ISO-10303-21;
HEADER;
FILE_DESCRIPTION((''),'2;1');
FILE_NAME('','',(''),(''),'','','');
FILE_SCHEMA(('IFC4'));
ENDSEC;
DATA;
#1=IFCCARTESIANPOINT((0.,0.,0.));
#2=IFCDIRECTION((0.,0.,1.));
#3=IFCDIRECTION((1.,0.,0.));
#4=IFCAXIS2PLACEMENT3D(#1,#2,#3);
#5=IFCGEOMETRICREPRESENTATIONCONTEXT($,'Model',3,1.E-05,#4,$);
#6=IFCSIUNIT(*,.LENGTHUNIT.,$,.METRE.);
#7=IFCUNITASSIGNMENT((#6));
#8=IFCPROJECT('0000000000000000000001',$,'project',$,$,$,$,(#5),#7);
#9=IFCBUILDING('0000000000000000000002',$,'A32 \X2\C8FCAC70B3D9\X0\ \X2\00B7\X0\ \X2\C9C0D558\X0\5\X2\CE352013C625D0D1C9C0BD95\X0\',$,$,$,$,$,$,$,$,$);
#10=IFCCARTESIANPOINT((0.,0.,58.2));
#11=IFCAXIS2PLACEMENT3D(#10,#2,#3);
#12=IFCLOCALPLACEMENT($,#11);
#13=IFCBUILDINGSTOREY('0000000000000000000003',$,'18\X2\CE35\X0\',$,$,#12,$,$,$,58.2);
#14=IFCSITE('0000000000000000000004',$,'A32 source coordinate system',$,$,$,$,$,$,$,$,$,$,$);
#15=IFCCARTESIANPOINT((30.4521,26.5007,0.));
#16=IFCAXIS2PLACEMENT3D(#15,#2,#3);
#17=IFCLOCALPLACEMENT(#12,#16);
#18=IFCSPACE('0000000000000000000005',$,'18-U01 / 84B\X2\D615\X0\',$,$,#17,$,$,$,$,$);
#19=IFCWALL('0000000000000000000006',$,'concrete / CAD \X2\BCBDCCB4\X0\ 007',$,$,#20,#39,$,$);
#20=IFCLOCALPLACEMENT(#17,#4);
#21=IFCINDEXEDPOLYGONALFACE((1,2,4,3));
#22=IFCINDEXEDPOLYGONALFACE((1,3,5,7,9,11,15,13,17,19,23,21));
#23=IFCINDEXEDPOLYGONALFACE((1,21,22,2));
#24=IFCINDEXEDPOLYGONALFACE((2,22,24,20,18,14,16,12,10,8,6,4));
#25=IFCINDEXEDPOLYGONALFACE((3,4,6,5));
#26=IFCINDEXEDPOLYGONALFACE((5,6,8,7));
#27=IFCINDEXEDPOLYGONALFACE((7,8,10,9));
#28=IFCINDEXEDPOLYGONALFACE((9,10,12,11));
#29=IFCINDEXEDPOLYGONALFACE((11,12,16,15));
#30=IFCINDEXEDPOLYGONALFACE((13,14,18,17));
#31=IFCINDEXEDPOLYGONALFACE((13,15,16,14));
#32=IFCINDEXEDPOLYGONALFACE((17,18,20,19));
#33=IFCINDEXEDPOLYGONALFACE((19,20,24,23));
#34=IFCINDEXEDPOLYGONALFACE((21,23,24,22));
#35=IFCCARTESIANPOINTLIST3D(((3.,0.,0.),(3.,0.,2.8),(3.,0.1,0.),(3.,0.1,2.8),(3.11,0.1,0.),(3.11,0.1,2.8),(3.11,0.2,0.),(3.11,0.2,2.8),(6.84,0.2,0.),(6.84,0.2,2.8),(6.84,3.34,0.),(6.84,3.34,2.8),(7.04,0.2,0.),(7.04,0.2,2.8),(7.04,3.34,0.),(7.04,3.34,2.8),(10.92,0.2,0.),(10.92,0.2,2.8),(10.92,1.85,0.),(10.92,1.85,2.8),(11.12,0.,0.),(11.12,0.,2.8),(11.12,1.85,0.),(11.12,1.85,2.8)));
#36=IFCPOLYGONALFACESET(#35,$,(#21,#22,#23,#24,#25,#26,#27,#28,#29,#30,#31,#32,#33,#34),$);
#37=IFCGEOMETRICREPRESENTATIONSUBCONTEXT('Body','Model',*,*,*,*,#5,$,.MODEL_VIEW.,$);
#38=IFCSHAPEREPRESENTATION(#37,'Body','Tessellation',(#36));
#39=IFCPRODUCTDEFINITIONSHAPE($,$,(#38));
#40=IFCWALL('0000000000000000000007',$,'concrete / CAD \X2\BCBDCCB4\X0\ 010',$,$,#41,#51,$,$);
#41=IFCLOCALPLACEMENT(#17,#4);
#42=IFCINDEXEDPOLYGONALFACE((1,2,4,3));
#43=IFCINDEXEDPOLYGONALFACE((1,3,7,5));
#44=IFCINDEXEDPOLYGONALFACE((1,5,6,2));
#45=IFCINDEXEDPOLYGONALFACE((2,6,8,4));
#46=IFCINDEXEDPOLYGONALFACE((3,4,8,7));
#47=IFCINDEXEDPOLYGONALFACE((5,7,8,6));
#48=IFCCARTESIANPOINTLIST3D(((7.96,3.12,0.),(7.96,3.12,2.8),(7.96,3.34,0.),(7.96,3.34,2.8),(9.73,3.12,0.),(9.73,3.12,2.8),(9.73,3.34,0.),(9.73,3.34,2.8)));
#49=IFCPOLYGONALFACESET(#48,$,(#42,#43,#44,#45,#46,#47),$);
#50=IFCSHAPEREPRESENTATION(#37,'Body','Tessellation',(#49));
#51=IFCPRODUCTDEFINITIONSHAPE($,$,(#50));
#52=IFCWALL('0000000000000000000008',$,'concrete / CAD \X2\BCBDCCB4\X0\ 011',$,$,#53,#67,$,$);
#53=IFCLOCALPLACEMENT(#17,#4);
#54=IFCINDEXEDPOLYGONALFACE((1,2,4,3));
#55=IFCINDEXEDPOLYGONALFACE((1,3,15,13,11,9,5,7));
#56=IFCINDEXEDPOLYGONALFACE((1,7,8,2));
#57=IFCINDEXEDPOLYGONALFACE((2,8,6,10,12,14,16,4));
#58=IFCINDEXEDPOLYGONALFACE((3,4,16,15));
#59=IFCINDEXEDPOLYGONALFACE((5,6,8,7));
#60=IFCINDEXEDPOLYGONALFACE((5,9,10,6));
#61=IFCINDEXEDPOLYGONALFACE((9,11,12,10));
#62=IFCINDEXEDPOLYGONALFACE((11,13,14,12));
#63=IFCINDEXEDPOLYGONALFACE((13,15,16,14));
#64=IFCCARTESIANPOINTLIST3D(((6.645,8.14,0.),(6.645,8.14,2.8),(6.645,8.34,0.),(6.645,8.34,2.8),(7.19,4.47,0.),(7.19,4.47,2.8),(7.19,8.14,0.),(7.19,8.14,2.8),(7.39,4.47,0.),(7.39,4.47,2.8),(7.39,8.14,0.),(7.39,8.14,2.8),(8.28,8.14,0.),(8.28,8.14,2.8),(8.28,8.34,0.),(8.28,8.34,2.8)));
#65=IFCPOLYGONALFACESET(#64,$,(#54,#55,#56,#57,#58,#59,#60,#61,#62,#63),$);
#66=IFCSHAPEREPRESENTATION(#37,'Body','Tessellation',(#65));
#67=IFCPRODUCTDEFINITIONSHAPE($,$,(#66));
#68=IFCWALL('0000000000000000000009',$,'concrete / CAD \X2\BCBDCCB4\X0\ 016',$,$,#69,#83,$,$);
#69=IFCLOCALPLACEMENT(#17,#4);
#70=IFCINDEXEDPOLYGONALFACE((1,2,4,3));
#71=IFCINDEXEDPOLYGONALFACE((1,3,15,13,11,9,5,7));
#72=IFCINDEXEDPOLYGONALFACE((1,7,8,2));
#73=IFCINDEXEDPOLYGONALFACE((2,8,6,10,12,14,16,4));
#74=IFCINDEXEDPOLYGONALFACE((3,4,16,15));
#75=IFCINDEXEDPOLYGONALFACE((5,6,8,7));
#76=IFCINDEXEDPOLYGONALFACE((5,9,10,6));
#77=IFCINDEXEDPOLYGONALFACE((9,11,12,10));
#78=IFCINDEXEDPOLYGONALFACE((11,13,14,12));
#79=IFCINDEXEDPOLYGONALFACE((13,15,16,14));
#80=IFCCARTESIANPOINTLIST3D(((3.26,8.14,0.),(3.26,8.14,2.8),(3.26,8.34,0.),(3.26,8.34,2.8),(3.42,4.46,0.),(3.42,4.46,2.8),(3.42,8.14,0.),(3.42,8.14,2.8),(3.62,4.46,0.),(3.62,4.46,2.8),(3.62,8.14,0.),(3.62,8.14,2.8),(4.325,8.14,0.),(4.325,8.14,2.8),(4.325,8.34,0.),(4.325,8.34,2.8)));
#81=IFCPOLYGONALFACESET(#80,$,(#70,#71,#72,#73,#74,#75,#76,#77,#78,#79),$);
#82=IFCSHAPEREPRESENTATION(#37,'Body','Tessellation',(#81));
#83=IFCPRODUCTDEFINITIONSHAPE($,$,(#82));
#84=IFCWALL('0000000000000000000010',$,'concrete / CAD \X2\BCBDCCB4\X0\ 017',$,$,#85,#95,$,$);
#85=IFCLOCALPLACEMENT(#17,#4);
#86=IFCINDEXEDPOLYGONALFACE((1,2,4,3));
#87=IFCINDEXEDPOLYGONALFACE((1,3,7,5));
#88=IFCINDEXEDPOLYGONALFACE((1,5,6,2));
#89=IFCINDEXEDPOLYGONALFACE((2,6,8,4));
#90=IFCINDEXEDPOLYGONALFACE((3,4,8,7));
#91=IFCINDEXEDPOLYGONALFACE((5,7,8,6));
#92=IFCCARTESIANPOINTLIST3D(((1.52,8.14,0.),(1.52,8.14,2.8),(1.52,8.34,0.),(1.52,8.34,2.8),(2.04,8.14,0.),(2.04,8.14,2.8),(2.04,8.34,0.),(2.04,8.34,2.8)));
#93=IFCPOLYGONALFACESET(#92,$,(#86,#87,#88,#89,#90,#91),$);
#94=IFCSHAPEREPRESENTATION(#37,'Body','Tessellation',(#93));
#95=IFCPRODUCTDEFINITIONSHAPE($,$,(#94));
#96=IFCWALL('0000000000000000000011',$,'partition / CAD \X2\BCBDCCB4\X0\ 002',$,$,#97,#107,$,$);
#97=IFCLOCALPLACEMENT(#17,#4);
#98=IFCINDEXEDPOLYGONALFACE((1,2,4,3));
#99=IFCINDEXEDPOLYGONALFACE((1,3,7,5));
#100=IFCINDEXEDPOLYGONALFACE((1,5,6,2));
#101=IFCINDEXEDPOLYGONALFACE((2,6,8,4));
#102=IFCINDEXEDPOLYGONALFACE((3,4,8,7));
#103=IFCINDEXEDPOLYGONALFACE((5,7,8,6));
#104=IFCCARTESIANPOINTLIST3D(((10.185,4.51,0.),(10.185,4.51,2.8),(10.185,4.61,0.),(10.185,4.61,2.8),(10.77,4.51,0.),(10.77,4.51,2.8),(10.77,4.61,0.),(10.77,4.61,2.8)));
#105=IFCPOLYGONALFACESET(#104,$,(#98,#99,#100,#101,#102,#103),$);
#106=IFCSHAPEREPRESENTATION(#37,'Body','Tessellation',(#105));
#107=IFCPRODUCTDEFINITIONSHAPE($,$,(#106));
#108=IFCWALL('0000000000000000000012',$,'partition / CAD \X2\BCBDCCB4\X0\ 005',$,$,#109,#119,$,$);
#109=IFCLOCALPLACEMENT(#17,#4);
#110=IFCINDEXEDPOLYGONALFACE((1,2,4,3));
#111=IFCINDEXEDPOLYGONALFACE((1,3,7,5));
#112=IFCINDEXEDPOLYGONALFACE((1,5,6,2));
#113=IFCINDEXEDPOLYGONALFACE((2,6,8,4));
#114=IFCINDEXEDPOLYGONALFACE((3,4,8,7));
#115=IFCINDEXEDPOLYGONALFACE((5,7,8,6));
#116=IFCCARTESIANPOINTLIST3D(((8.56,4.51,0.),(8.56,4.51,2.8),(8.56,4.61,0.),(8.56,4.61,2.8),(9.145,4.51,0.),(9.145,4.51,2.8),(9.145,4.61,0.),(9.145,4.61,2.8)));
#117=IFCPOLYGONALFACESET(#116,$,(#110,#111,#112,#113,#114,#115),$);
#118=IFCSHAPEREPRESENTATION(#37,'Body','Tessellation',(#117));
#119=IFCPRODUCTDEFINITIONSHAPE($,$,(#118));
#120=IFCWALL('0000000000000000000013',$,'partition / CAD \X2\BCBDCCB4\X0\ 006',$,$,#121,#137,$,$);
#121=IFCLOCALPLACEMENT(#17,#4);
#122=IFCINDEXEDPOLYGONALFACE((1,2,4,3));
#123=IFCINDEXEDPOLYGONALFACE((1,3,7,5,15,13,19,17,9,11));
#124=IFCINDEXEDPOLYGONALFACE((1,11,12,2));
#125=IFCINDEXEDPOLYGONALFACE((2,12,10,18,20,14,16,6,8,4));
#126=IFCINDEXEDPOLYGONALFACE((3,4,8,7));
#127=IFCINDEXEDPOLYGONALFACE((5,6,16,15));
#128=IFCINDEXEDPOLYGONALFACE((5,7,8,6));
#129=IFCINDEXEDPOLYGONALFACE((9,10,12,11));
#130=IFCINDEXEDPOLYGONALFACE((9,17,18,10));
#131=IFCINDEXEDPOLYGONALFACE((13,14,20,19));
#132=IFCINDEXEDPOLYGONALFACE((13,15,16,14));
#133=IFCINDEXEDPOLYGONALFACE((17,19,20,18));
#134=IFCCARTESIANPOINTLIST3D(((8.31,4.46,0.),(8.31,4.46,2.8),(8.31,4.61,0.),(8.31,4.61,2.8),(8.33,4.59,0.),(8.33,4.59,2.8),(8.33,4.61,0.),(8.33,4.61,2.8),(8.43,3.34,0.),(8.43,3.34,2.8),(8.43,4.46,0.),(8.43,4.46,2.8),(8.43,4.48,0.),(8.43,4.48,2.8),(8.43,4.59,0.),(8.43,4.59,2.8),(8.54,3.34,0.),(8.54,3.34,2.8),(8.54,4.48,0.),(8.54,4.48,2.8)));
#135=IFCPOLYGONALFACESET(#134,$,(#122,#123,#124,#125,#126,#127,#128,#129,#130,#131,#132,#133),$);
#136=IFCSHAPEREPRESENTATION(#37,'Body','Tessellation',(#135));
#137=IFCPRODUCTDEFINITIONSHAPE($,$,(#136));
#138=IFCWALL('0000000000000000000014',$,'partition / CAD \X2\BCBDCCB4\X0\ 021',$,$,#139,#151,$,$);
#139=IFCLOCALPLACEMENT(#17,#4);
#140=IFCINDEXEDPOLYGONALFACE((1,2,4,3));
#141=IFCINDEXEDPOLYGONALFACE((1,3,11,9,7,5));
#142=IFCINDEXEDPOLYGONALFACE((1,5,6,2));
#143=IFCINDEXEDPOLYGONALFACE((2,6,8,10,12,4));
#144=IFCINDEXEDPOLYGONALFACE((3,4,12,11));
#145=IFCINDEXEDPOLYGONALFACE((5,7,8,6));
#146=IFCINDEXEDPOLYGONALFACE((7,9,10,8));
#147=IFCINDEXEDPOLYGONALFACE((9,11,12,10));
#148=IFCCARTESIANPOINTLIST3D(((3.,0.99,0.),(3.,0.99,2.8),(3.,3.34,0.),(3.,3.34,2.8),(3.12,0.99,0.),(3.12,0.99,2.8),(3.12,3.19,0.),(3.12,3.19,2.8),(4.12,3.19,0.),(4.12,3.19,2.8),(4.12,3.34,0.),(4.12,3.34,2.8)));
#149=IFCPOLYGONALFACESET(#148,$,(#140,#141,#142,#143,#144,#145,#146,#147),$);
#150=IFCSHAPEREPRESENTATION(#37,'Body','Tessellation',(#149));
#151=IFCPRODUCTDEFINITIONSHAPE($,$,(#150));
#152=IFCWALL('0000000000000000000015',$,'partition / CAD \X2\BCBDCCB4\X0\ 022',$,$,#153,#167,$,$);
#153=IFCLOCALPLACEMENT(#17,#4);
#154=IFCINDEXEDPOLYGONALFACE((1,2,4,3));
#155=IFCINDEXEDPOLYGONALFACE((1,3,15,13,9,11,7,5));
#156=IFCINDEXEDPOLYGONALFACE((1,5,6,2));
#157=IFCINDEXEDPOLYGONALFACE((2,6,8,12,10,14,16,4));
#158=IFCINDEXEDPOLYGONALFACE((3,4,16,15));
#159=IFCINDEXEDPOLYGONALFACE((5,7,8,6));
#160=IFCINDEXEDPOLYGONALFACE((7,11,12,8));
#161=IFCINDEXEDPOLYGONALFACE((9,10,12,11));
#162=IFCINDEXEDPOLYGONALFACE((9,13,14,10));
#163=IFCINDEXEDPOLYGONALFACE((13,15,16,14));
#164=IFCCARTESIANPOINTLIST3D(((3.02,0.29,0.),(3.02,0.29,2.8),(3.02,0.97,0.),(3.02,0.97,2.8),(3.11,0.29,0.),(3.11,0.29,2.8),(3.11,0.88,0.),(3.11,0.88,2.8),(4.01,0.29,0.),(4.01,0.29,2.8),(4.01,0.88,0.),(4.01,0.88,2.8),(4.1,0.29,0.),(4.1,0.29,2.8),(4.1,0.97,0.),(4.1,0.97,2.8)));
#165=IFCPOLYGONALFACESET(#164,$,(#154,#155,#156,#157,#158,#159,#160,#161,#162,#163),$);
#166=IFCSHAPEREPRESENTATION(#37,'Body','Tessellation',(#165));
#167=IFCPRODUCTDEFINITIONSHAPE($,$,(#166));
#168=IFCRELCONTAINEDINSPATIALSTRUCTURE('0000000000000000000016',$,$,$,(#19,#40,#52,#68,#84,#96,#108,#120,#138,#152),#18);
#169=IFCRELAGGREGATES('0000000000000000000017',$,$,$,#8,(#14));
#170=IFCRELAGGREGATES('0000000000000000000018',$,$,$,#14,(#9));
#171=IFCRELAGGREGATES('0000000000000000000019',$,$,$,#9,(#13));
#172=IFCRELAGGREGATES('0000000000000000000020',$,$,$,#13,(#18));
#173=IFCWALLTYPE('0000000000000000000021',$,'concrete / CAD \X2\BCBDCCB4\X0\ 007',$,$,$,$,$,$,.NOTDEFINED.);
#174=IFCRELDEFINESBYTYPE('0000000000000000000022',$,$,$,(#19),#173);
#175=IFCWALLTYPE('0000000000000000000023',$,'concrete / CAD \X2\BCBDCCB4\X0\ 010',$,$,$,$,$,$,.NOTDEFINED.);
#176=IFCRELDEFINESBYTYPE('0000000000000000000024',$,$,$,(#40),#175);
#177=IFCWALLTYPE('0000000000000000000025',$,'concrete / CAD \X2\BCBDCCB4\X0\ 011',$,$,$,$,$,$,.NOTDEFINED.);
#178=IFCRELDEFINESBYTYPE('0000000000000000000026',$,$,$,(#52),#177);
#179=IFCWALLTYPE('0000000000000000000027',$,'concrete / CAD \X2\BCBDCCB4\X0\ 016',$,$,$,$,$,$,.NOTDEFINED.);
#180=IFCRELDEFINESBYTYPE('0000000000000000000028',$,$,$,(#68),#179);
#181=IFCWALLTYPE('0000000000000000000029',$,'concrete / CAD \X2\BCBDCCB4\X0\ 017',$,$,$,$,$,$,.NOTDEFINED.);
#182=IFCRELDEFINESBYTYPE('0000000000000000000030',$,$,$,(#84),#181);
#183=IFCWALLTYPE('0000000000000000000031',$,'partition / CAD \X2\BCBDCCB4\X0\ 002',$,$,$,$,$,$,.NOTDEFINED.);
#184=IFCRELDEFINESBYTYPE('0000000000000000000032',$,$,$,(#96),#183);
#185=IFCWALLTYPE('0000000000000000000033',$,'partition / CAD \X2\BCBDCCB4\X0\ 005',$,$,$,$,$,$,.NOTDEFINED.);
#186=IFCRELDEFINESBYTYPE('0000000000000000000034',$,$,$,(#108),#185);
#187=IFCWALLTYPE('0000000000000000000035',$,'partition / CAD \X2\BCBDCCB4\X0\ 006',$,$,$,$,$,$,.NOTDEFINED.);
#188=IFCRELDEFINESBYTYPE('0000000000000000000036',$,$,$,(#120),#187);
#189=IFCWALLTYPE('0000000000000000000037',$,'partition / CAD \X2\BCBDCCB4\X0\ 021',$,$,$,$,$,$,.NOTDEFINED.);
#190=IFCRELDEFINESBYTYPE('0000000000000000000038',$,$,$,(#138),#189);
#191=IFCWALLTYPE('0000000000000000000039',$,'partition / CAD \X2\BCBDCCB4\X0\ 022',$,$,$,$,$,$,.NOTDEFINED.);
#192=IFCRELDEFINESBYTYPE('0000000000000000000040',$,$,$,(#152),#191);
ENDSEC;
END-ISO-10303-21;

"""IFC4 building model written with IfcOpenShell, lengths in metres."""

from ifc_helpers import new_model, si_unit, frame, origin, origin_with_axes, place, context, subcontext, project, spatial, polyline, outline, extrude, source, transform, mapped, type_object, type_shapes, element, save


model = new_model("IFC4")

# Units and contexts
model_context = context("Model", 3, precision=1e-05, world=origin_with_axes())
body_context = subcontext(model_context, "Body", "Model", "MODEL_VIEW")
ifc_project = project(units=[si_unit("LENGTHUNIT", "METRE")], contexts=[model_context])

# Site, building, storey, space
site = spatial("IfcSite", under=ifc_project, Name="A32 source coordinate system")
building = spatial("IfcBuilding", under=site, Name="A32 주거동 · 지하5층–옥탑지붕")
storey_placement = place(None, frame((0.0, 0.0, 58.2), z_axis=(0.0, 0.0, 1.0), x_axis=(1.0, 0.0, 0.0)))
storey = spatial("IfcBuildingStorey", under=building, at=storey_placement, Name="18층", Elevation=58.2)
space_1_placement = place(storey_placement, frame((30.4521, 26.5007, 0.0), z_axis=(0.0, 0.0, 1.0), x_axis=(1.0, 0.0, 0.0)))
space_1 = spatial("IfcSpace", under=storey, at=space_1_placement, Name="18-U01 / 84B형")

# Walls
wall_type_1 = type_object("IfcWallType", Name="concrete / CAD 벽체 007", PredefinedType="NOTDEFINED")
shared_shape_1 = source(origin(), body_context, "Body", "SweptSolid", [
    extrude(outline(polyline([(3.0, 0.0), (3.0, 0.1), (3.11, 0.1), (3.11, 0.2), (6.84, 0.2), (6.84, 3.34), (7.04, 3.34), (7.04, 0.2), (10.92, 0.2), (10.92, 1.85), (11.12, 1.85), (11.12, 0.0), (3.0, 0.0)])), origin(), (0.0, 0.0, 1.0), 2.8),
])
type_shapes(wall_type_1, [shared_shape_1])
wall_1_placement = place(space_1_placement, origin_with_axes())
element("IfcWall", 1, at=wall_1_placement, inside=space_1, type_object=wall_type_1, Name="concrete / CAD 벽체 007", context=body_context, shape_type="MappedRepresentation", body=[
    mapped(shared_shape_1, transform((0.0, 0.0, 0.0), scale=1.0)),
])
wall_type_2 = type_object("IfcWallType", Name="concrete / CAD 벽체 010", PredefinedType="NOTDEFINED")
shared_shape_2 = source(origin(), body_context, "Body", "SweptSolid", [
    extrude(outline(polyline([(7.96, 3.12), (7.96, 3.34), (9.73, 3.34), (9.73, 3.12), (7.96, 3.12)])), origin(), (0.0, 0.0, 1.0), 2.8),
])
type_shapes(wall_type_2, [shared_shape_2])
wall_2_placement = place(space_1_placement, origin_with_axes())
element("IfcWall", 2, at=wall_2_placement, inside=space_1, type_object=wall_type_2, Name="concrete / CAD 벽체 010", context=body_context, shape_type="MappedRepresentation", body=[
    mapped(shared_shape_2, transform((0.0, 0.0, 0.0), scale=1.0)),
])
wall_type_3 = type_object("IfcWallType", Name="concrete / CAD 벽체 011", PredefinedType="NOTDEFINED")
shared_shape_3 = source(origin(), body_context, "Body", "SweptSolid", [
    extrude(outline(polyline([(7.19, 8.14), (6.645, 8.14), (6.645, 8.34), (8.28, 8.34), (8.28, 8.14), (7.39, 8.14), (7.39, 4.47), (7.19, 4.47), (7.19, 8.14)])), origin(), (0.0, 0.0, 1.0), 2.8),
])
type_shapes(wall_type_3, [shared_shape_3])
wall_3_placement = place(space_1_placement, origin_with_axes())
element("IfcWall", 3, at=wall_3_placement, inside=space_1, type_object=wall_type_3, Name="concrete / CAD 벽체 011", context=body_context, shape_type="MappedRepresentation", body=[
    mapped(shared_shape_3, transform((0.0, 0.0, 0.0), scale=1.0)),
])
wall_type_4 = type_object("IfcWallType", Name="concrete / CAD 벽체 016", PredefinedType="NOTDEFINED")
shared_shape_4 = source(origin(), body_context, "Body", "SweptSolid", [
    extrude(outline(polyline([(3.26, 8.14), (3.26, 8.34), (4.325, 8.34), (4.325, 8.14), (3.62, 8.14), (3.62, 4.46), (3.42, 4.46), (3.42, 8.14), (3.26, 8.14)])), origin(), (0.0, 0.0, 1.0), 2.8),
])
type_shapes(wall_type_4, [shared_shape_4])
wall_4_placement = place(space_1_placement, origin_with_axes())
element("IfcWall", 4, at=wall_4_placement, inside=space_1, type_object=wall_type_4, Name="concrete / CAD 벽체 016", context=body_context, shape_type="MappedRepresentation", body=[
    mapped(shared_shape_4, transform((0.0, 0.0, 0.0), scale=1.0)),
])
wall_type_5 = type_object("IfcWallType", Name="concrete / CAD 벽체 017", PredefinedType="NOTDEFINED")
shared_shape_5 = source(origin(), body_context, "Body", "SweptSolid", [
    extrude(outline(polyline([(1.52, 8.34), (2.04, 8.34), (2.04, 8.14), (1.52, 8.14), (1.52, 8.34)])), origin(), (0.0, 0.0, 1.0), 2.8),
])
type_shapes(wall_type_5, [shared_shape_5])
wall_5_placement = place(space_1_placement, origin_with_axes())
element("IfcWall", 5, at=wall_5_placement, inside=space_1, type_object=wall_type_5, Name="concrete / CAD 벽체 017", context=body_context, shape_type="MappedRepresentation", body=[
    mapped(shared_shape_5, transform((0.0, 0.0, 0.0), scale=1.0)),
])
wall_type_6 = type_object("IfcWallType", Name="partition / CAD 벽체 002", PredefinedType="NOTDEFINED")
shared_shape_6 = source(origin(), body_context, "Body", "SweptSolid", [
    extrude(outline(polyline([(10.185, 4.51), (10.185, 4.61), (10.77, 4.61), (10.77, 4.51), (10.185, 4.51)])), origin(), (0.0, 0.0, 1.0), 2.8),
])
type_shapes(wall_type_6, [shared_shape_6])
wall_6_placement = place(space_1_placement, origin_with_axes())
element("IfcWall", 6, at=wall_6_placement, inside=space_1, type_object=wall_type_6, Name="partition / CAD 벽체 002", context=body_context, shape_type="MappedRepresentation", body=[
    mapped(shared_shape_6, transform((0.0, 0.0, 0.0), scale=1.0)),
])
wall_type_7 = type_object("IfcWallType", Name="partition / CAD 벽체 005", PredefinedType="NOTDEFINED")
shared_shape_7 = source(origin(), body_context, "Body", "SweptSolid", [
    extrude(outline(polyline([(8.56, 4.51), (8.56, 4.61), (9.145, 4.61), (9.145, 4.51), (8.56, 4.51)])), origin(), (0.0, 0.0, 1.0), 2.8),
])
type_shapes(wall_type_7, [shared_shape_7])
wall_7_placement = place(space_1_placement, origin_with_axes())
element("IfcWall", 7, at=wall_7_placement, inside=space_1, type_object=wall_type_7, Name="partition / CAD 벽체 005", context=body_context, shape_type="MappedRepresentation", body=[
    mapped(shared_shape_7, transform((0.0, 0.0, 0.0), scale=1.0)),
])
wall_type_8 = type_object("IfcWallType", Name="partition / CAD 벽체 006", PredefinedType="NOTDEFINED")
shared_shape_8 = source(origin(), body_context, "Body", "SweptSolid", [
    extrude(outline(polyline([(8.43, 4.46), (8.31, 4.46), (8.31, 4.61), (8.33, 4.61), (8.33, 4.59), (8.43, 4.59), (8.43, 4.48), (8.54, 4.48), (8.54, 3.34), (8.43, 3.34), (8.43, 4.46)])), origin(), (0.0, 0.0, 1.0), 2.8),
])
type_shapes(wall_type_8, [shared_shape_8])
wall_8_placement = place(space_1_placement, origin_with_axes())
element("IfcWall", 8, at=wall_8_placement, inside=space_1, type_object=wall_type_8, Name="partition / CAD 벽체 006", context=body_context, shape_type="MappedRepresentation", body=[
    mapped(shared_shape_8, transform((0.0, 0.0, 0.0), scale=1.0)),
])
wall_type_9 = type_object("IfcWallType", Name="partition / CAD 벽체 021", PredefinedType="NOTDEFINED")
shared_shape_9 = source(origin(), body_context, "Body", "SweptSolid", [
    extrude(outline(polyline([(4.12, 3.34), (4.12, 3.19), (3.12, 3.19), (3.12, 0.99), (3.0, 0.99), (3.0, 3.34), (4.12, 3.34)])), origin(), (0.0, 0.0, 1.0), 2.8),
])
type_shapes(wall_type_9, [shared_shape_9])
wall_9_placement = place(space_1_placement, origin_with_axes())
element("IfcWall", 9, at=wall_9_placement, inside=space_1, type_object=wall_type_9, Name="partition / CAD 벽체 021", context=body_context, shape_type="MappedRepresentation", body=[
    mapped(shared_shape_9, transform((0.0, 0.0, 0.0), scale=1.0)),
])
wall_type_10 = type_object("IfcWallType", Name="partition / CAD 벽체 022", PredefinedType="NOTDEFINED")
shared_shape_10 = source(origin(), body_context, "Body", "SweptSolid", [
    extrude(outline(polyline([(4.1, 0.97), (4.1, 0.29), (4.01, 0.29), (4.01, 0.88), (3.11, 0.88), (3.11, 0.29), (3.02, 0.29), (3.02, 0.97), (4.1, 0.97)])), origin(), (0.0, 0.0, 1.0), 2.8),
])
type_shapes(wall_type_10, [shared_shape_10])
wall_10_placement = place(space_1_placement, origin_with_axes())
element("IfcWall", 10, at=wall_10_placement, inside=space_1, type_object=wall_type_10, Name="partition / CAD 벽체 022", context=body_context, shape_type="MappedRepresentation", body=[
    mapped(shared_shape_10, transform((0.0, 0.0, 0.0), scale=1.0)),
])

save(model, "model.ifc")
